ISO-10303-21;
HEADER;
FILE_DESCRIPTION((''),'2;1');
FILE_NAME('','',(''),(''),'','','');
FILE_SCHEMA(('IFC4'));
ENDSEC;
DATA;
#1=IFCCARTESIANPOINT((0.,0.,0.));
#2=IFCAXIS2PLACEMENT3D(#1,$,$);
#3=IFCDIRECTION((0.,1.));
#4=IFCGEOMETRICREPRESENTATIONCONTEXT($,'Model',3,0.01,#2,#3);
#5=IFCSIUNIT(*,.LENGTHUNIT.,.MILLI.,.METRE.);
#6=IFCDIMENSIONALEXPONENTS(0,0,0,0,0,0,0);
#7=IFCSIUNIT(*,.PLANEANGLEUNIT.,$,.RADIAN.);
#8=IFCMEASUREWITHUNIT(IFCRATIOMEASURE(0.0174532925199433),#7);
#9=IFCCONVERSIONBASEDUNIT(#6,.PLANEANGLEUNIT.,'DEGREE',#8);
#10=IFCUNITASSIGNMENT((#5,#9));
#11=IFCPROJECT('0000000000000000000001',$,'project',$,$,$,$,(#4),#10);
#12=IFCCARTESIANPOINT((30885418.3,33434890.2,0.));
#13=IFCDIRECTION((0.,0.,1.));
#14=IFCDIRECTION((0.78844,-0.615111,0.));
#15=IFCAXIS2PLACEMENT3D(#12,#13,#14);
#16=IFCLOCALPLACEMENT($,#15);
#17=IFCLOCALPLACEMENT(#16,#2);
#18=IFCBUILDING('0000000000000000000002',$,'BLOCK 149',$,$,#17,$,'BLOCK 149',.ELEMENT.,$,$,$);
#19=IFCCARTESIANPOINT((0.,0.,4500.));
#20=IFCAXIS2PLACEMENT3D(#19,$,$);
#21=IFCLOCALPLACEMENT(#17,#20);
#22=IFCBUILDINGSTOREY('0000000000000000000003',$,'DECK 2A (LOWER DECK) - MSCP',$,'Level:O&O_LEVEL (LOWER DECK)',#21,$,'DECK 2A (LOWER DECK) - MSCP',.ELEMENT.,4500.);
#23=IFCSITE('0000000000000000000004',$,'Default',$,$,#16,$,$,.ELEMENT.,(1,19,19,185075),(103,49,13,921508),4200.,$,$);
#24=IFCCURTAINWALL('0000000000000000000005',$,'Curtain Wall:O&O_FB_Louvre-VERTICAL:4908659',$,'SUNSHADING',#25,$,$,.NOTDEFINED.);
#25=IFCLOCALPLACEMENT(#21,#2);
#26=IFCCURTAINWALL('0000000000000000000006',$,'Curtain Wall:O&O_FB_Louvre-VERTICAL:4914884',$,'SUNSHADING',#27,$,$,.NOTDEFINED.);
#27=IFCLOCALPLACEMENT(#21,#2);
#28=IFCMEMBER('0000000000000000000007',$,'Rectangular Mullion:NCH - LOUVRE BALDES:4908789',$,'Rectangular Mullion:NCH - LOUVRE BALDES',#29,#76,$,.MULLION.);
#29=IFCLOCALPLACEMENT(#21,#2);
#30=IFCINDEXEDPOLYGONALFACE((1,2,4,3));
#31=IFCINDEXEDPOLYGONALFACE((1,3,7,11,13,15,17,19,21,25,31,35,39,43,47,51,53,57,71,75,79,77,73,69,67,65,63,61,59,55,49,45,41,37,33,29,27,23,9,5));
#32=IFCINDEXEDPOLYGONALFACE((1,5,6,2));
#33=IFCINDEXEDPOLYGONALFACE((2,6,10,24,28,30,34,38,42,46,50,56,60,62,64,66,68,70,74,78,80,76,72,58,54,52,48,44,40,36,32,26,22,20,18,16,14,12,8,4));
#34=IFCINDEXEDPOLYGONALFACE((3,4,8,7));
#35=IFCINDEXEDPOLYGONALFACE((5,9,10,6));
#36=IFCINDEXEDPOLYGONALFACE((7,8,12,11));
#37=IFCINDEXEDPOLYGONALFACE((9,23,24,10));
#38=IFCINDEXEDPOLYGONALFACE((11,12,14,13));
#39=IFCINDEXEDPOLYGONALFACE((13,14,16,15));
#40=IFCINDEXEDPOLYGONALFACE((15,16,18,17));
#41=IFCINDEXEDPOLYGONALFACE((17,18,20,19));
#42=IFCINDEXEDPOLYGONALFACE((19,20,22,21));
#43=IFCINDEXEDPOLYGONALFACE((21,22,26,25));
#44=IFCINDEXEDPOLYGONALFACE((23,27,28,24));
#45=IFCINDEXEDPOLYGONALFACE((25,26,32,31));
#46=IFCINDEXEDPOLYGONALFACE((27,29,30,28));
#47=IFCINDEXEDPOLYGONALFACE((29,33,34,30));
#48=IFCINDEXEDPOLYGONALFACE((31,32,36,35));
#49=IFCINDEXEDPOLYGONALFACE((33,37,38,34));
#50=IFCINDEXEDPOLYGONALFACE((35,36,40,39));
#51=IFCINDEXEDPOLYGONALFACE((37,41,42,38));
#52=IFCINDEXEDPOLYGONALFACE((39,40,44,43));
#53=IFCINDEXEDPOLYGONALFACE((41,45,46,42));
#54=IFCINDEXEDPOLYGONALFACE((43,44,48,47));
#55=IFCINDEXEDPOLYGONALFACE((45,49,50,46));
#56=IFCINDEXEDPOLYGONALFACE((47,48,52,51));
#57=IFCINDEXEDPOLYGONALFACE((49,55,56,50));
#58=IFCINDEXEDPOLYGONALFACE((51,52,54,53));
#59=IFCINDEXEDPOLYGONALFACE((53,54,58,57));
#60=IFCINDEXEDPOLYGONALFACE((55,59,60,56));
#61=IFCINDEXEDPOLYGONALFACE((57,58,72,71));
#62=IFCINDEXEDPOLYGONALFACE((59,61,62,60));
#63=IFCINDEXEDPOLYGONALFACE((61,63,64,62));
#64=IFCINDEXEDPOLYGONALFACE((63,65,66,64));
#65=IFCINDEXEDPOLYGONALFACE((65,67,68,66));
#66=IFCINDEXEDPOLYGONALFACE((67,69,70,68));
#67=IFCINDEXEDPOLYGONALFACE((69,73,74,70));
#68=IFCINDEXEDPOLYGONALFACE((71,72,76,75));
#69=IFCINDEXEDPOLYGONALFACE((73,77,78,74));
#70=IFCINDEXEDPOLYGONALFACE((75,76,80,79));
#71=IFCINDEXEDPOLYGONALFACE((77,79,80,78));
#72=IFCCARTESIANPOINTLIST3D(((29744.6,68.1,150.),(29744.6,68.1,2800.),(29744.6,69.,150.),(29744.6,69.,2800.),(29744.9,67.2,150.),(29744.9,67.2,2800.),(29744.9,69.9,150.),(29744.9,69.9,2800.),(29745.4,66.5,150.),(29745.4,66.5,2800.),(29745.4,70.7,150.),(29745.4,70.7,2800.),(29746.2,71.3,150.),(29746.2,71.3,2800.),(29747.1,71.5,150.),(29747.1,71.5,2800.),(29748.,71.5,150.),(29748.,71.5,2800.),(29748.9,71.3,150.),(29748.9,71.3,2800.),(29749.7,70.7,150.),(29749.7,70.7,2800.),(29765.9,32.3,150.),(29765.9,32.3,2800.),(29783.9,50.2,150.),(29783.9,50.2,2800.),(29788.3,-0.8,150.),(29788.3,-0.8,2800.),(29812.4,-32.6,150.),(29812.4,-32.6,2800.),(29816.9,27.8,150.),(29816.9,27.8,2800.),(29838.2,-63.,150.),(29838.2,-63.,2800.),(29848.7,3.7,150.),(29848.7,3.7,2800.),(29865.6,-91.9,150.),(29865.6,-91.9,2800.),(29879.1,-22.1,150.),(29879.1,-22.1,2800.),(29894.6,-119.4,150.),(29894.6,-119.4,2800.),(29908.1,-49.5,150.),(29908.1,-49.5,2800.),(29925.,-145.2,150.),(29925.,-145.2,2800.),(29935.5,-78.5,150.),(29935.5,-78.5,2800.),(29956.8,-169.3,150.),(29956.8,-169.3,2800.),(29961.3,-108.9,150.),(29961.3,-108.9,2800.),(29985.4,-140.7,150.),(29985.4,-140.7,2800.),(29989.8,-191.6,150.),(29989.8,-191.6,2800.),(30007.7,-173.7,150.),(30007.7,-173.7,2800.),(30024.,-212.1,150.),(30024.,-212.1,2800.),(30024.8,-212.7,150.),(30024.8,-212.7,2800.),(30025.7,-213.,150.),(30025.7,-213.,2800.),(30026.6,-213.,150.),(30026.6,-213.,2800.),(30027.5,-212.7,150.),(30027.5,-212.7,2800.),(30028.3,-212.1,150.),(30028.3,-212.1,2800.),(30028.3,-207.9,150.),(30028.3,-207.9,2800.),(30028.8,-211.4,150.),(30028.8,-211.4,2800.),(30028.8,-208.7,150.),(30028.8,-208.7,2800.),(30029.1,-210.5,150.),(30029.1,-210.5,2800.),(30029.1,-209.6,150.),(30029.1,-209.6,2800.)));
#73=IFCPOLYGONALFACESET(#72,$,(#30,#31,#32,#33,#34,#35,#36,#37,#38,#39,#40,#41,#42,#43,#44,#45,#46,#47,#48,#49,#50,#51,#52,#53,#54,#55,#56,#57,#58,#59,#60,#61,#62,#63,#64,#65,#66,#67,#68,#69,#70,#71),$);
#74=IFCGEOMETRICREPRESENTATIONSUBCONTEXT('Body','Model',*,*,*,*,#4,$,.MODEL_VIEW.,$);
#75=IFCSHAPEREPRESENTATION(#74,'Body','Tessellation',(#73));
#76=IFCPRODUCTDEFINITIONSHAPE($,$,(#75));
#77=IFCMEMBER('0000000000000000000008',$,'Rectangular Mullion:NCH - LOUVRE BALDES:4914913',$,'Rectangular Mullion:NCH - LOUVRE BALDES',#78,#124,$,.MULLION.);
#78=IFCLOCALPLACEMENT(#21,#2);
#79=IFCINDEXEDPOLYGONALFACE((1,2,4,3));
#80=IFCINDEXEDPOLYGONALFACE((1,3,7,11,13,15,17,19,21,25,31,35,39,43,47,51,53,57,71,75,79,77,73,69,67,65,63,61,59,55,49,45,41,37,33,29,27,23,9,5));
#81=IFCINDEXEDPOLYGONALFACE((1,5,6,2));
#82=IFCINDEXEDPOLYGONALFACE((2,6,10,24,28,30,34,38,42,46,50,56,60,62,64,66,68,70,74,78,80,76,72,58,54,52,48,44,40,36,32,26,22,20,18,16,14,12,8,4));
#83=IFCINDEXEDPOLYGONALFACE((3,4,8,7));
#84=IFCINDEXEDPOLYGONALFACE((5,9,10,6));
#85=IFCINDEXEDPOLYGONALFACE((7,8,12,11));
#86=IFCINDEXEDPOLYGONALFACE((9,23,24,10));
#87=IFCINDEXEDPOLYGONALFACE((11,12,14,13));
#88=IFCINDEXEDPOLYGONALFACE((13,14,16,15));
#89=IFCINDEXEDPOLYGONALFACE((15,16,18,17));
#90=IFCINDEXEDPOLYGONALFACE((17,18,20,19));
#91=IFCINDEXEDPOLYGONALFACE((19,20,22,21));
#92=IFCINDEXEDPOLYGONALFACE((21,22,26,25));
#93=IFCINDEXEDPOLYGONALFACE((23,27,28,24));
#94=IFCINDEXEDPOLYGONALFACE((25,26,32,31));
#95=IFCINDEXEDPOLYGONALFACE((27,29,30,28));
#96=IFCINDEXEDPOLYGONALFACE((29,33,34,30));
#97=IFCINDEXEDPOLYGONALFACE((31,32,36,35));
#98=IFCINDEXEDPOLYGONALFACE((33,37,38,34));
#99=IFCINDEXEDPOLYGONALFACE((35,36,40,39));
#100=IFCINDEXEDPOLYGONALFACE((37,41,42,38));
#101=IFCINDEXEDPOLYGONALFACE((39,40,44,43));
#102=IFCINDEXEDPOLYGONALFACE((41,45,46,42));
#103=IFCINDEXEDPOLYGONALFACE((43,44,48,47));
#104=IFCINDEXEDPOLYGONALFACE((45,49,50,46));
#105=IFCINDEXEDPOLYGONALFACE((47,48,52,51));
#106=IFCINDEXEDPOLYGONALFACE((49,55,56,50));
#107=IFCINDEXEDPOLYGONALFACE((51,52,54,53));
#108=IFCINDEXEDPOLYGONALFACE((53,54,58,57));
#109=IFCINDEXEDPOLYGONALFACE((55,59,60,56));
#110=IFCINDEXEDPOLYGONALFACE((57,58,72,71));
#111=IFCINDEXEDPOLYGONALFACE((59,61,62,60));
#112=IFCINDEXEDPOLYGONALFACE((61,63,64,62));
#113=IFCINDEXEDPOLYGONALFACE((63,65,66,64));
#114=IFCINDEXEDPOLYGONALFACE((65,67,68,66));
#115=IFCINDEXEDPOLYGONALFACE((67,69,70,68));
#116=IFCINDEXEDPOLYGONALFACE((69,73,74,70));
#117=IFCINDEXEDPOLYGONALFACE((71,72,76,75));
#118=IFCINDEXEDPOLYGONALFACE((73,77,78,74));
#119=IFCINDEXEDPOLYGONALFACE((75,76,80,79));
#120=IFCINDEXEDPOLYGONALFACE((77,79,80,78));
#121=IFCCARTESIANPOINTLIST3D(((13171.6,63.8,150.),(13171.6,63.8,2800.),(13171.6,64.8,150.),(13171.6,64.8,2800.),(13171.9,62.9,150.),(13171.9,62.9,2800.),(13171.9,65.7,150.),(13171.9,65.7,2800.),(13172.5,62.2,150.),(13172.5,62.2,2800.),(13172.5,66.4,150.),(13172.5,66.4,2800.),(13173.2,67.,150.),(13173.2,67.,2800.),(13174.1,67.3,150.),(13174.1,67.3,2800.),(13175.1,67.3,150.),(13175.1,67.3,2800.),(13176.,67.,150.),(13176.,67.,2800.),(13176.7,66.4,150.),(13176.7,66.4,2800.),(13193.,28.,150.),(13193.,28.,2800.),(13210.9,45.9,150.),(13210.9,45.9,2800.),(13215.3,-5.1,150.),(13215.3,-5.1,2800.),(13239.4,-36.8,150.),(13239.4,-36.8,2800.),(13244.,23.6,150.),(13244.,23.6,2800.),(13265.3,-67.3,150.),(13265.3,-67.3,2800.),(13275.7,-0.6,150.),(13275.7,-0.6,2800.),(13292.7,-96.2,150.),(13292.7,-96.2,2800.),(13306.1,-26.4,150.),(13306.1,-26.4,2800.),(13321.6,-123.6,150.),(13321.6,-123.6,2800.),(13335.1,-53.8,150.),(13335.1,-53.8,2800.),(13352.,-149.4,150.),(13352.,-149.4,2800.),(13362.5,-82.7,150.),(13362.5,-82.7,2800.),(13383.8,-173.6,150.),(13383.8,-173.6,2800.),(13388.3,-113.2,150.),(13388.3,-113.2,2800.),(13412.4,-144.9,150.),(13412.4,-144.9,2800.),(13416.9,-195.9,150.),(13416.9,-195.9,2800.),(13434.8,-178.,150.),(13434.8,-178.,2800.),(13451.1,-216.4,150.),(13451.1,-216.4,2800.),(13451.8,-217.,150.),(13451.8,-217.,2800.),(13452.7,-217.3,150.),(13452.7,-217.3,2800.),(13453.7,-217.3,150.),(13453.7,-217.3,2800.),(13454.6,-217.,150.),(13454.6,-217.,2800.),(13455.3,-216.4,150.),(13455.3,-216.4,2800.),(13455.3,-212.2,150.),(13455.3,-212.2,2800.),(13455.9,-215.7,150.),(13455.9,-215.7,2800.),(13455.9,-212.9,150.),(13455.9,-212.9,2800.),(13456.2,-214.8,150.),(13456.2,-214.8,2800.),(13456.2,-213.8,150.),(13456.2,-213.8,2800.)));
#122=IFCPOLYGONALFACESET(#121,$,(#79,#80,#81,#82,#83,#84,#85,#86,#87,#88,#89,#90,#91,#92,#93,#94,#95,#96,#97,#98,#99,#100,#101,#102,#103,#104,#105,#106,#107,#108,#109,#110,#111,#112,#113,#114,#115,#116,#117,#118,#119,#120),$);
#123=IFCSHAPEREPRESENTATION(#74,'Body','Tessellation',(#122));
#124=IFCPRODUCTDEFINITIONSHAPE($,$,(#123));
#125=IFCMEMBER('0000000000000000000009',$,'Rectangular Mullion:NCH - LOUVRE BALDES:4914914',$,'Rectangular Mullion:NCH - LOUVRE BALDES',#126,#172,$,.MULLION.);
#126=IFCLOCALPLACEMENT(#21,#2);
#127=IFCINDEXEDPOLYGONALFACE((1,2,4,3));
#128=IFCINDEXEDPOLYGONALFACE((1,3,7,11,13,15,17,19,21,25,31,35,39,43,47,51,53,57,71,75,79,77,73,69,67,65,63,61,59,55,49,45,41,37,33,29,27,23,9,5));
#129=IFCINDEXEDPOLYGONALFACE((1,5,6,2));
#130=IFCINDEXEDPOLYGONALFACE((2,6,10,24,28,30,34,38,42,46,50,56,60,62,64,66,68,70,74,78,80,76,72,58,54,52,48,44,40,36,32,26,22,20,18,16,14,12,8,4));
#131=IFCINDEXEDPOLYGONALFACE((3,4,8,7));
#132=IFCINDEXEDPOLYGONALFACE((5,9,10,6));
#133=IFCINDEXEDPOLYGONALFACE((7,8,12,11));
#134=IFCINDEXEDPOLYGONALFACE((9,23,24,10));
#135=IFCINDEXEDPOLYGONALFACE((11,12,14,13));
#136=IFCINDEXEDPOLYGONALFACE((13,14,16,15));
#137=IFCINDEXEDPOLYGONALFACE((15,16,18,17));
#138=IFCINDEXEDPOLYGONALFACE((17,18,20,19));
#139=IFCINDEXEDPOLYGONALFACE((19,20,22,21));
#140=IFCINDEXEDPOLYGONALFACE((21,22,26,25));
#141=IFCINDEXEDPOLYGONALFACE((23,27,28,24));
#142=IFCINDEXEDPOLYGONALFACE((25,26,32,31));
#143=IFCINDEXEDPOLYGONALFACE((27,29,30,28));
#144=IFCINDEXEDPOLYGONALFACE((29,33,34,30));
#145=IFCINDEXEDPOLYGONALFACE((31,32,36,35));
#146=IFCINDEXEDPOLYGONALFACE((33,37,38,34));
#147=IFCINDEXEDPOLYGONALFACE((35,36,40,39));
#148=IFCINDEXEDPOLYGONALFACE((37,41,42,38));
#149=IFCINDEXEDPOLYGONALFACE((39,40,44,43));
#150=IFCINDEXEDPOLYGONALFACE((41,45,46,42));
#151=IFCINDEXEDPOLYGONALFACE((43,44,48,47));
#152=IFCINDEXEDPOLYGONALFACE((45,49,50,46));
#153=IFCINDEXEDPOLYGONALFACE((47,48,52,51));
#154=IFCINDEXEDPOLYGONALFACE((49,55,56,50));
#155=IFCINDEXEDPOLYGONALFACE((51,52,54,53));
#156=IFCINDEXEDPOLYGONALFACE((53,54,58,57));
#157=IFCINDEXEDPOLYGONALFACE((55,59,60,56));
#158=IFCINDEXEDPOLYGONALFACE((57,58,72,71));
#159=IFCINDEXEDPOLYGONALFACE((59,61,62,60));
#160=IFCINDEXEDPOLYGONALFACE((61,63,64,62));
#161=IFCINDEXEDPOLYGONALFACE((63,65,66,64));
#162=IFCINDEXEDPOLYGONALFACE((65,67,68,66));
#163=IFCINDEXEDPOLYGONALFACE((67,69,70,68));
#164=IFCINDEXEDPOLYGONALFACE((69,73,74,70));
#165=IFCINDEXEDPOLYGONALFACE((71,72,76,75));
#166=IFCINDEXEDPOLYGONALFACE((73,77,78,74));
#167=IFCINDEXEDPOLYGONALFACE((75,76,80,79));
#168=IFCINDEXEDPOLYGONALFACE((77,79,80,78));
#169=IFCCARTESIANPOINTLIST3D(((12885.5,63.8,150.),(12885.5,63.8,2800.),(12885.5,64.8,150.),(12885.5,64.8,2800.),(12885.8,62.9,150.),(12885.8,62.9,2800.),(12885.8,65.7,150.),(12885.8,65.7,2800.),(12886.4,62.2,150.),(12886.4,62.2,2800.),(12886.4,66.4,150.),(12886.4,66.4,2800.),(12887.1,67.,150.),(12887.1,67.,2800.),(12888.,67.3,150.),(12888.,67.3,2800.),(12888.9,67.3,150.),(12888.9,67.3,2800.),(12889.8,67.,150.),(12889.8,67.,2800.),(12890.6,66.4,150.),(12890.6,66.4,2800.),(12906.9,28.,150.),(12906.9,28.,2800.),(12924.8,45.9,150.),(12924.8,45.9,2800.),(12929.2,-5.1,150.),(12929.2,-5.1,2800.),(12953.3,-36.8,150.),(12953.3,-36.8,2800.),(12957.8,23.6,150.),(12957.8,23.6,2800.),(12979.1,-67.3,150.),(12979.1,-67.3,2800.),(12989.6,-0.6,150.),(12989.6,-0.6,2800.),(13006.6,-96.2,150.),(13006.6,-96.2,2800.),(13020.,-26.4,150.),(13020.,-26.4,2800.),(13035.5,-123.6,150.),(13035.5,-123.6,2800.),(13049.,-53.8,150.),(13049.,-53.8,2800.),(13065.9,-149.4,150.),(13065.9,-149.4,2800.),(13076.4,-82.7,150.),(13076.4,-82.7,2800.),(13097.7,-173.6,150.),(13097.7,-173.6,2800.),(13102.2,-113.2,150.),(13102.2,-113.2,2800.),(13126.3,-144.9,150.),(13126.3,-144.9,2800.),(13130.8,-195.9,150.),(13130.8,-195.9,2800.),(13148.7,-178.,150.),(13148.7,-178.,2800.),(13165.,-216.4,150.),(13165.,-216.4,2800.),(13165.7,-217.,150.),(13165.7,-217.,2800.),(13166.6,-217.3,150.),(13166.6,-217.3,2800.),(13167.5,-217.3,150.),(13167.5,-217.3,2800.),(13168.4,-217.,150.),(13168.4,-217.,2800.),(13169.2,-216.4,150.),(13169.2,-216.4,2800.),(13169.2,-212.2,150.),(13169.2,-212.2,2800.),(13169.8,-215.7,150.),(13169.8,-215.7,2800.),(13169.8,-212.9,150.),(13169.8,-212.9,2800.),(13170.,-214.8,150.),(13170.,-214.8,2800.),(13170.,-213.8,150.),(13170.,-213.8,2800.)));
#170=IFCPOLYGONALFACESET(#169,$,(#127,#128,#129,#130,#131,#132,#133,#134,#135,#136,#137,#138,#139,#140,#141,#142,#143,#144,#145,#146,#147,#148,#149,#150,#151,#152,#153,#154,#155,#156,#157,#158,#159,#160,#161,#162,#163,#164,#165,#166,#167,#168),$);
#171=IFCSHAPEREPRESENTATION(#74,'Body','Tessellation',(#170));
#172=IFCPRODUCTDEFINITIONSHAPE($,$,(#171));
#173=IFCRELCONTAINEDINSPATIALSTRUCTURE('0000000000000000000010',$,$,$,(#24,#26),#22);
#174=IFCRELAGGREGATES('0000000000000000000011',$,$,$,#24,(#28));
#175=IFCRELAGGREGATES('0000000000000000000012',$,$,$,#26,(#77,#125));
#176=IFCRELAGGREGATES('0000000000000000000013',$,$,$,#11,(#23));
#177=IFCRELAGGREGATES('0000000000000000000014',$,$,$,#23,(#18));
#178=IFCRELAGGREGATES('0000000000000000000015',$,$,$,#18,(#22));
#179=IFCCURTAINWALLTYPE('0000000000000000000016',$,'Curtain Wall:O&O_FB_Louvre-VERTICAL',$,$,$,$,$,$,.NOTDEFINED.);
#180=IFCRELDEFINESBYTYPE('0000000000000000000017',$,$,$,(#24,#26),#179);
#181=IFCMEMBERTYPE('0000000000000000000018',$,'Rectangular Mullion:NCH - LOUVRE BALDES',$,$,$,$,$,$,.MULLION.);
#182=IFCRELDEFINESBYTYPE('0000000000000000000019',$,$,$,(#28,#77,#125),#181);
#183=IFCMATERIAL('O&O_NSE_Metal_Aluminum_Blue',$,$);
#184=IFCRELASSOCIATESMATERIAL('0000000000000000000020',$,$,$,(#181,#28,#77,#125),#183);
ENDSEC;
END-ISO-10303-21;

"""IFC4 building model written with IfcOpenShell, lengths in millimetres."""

from ifc_helpers import new_model, entity, si_unit, converted_unit, direction, frame, origin, place, context, subcontext, project, spatial, indexed_curve, outline, extrude, source, transform, mapped, material, type_object, type_shapes, element, aggregate, save


model = new_model("IFC4")

# Units and contexts
model_context = context("Model", 3, precision=0.01, world=origin(), true_north=direction((0.0, 1.0)))
body_context = subcontext(model_context, "Body", "Model", "MODEL_VIEW")
ifc_project = project(units=[si_unit("LENGTHUNIT", "METRE", prefix="MILLI"), converted_unit("PLANEANGLEUNIT", "DEGREE", entity("IfcRatioMeasure", 0.0174532925199433), si_unit("PLANEANGLEUNIT", "RADIAN"), dimensions=[0, 0, 0, 0, 0, 0, 0])], contexts=[model_context])

# Site, building, storey
site_placement = place(None, frame((30885418.3, 33434890.2, 0.0), z_axis=(0.0, 0.0, 1.0), x_axis=(0.78844, -0.615111, 0.0)))
site = spatial("IfcSite", under=ifc_project, at=site_placement, Name="Default", CompositionType="ELEMENT", RefLatitude=(1, 19, 19, 185075), RefLongitude=(103, 49, 13, 921508), RefElevation=4200.0)
building_placement = place(site_placement, origin())
building = spatial("IfcBuilding", under=site, at=building_placement, Name="BLOCK 149", LongName="BLOCK 149", CompositionType="ELEMENT")
storey_placement = place(building_placement, frame((0.0, 0.0, 4500.0)))
storey = spatial("IfcBuildingStorey", under=building, at=storey_placement, Name="DECK 2A (LOWER DECK) - MSCP", ObjectType="Level:O&O_LEVEL (LOWER DECK)", LongName="DECK 2A (LOWER DECK) - MSCP", CompositionType="ELEMENT", Elevation=4500.0)

# Curtain wall
curtain_wall_type = type_object("IfcCurtainWallType", Name="Curtain Wall:O&O_FB_Louvre-VERTICAL", PredefinedType="NOTDEFINED")
curtain_wall_1_placement = place(storey_placement, frame((0.0, 0.0, -4500.0)))
curtain_wall_1 = element("IfcCurtainWall", 1, at=curtain_wall_1_placement, inside=storey, type_object=curtain_wall_type, Name="Curtain Wall:O&O_FB_Louvre-VERTICAL:4908659", ObjectType="SUNSHADING", PredefinedType="NOTDEFINED")
placement = place(building_placement, origin())

# Curtain wall
curtain_wall_2_placement = place(storey_placement, frame((0.0, 0.0, -4500.0)))
curtain_wall_2 = element("IfcCurtainWall", 2, at=curtain_wall_2_placement, inside=storey, type_object=curtain_wall_type, Name="Curtain Wall:O&O_FB_Louvre-VERTICAL:4914884", ObjectType="SUNSHADING", PredefinedType="NOTDEFINED")

# Members
ifc_material_1 = material(Name="O&O_NSE_Metal_Aluminum_Blue")
member_type_1 = type_object("IfcMemberType", Name="Rectangular Mullion:NCH - LOUVRE BALDES", PredefinedType="MULLION", material=ifc_material_1)
shared_shape_1 = source(origin(), body_context, "Body", "SweptSolid", [
    extrude(outline(indexed_curve([(55.9, -188.9), (54.8, -149.1), (51.6, -109.3), (46.1, -69.8), (38.6, -30.6), (28.9, 8.1), (17.1, 46.2), (3.3, 83.6), (-12.6, 120.2), (-30.4, 155.9), (-50.1, 190.5), (-50.5, 191.4), (-51.1, 192.1), (-52.0, 192.5), (-52.9, 192.7), (-53.8, 192.6), (-54.7, 192.2), (-55.4, 191.6), (-55.8, 190.8), (-56.0, 189.9), (-55.9, 188.9), (-54.8, 149.1), (-51.6, 109.3), (-46.1, 69.8), (-38.6, 30.6), (-28.9, -8.1), (-17.1, -46.2), (-3.3, -83.6), (12.6, -120.2), (30.4, -155.9), (50.1, -190.5), (50.5, -191.4), (51.1, -192.1), (52.0, -192.5), (52.9, -192.7), (53.8, -192.6), (54.7, -192.2), (55.4, -191.6), (55.8, -190.8), (56.0, -189.9), (55.9, -188.9)], self_intersect=False)), frame((0.0, 0.0, -2650.0), z_axis=(0.0, 0.0, 1.0), x_axis=(0.490779, -0.871284, 0.0)), (0.0, 0.0, 1.0), 2650.0),
])
type_shapes(member_type_1, [shared_shape_1])
member_1_placement = place(placement, frame((29886.8, -70.7, 4650.0), z_axis=(0.0, 0.0, -1.0), x_axis=(-1.0, 0.0, 0.0)))
member_1 = element("IfcMember", 3, at=member_1_placement, type_object=member_type_1, material=ifc_material_1, Name="Rectangular Mullion:NCH - LOUVRE BALDES:4908789", ObjectType="Rectangular Mullion:NCH - LOUVRE BALDES", PredefinedType="MULLION", context=body_context, shape_type="MappedRepresentation", body=[
    mapped(shared_shape_1, transform((0.0, 0.0, 0.0), scale=1.0)),
])
member_2_placement = place(storey_placement, frame((13313.9, -75.0, 150.0), z_axis=(0.0, 0.0, -1.0), x_axis=(-1.0, 0.0, 0.0)))
member_2 = element("IfcMember", 4, at=member_2_placement, type_object=member_type_1, material=ifc_material_1, Name="Rectangular Mullion:NCH - LOUVRE BALDES:4914913", ObjectType="Rectangular Mullion:NCH - LOUVRE BALDES", PredefinedType="MULLION", context=body_context, shape_type="MappedRepresentation", body=[
    mapped(shared_shape_1, transform((0.0, 0.0, 0.0), scale=1.0)),
])
member_3_placement = place(storey_placement, frame((13027.8, -75.0, 150.0), z_axis=(0.0, 0.0, -1.0), x_axis=(-1.0, 0.0, 0.0)))
member_3 = element("IfcMember", 5, at=member_3_placement, type_object=member_type_1, material=ifc_material_1, Name="Rectangular Mullion:NCH - LOUVRE BALDES:4914914", ObjectType="Rectangular Mullion:NCH - LOUVRE BALDES", PredefinedType="MULLION", context=body_context, shape_type="MappedRepresentation", body=[
    mapped(shared_shape_1, transform((0.0, 0.0, 0.0), scale=1.0)),
])
aggregate(curtain_wall_1, [member_1])
aggregate(curtain_wall_2, [member_2, member_3])

save(model, "model.ifc")
